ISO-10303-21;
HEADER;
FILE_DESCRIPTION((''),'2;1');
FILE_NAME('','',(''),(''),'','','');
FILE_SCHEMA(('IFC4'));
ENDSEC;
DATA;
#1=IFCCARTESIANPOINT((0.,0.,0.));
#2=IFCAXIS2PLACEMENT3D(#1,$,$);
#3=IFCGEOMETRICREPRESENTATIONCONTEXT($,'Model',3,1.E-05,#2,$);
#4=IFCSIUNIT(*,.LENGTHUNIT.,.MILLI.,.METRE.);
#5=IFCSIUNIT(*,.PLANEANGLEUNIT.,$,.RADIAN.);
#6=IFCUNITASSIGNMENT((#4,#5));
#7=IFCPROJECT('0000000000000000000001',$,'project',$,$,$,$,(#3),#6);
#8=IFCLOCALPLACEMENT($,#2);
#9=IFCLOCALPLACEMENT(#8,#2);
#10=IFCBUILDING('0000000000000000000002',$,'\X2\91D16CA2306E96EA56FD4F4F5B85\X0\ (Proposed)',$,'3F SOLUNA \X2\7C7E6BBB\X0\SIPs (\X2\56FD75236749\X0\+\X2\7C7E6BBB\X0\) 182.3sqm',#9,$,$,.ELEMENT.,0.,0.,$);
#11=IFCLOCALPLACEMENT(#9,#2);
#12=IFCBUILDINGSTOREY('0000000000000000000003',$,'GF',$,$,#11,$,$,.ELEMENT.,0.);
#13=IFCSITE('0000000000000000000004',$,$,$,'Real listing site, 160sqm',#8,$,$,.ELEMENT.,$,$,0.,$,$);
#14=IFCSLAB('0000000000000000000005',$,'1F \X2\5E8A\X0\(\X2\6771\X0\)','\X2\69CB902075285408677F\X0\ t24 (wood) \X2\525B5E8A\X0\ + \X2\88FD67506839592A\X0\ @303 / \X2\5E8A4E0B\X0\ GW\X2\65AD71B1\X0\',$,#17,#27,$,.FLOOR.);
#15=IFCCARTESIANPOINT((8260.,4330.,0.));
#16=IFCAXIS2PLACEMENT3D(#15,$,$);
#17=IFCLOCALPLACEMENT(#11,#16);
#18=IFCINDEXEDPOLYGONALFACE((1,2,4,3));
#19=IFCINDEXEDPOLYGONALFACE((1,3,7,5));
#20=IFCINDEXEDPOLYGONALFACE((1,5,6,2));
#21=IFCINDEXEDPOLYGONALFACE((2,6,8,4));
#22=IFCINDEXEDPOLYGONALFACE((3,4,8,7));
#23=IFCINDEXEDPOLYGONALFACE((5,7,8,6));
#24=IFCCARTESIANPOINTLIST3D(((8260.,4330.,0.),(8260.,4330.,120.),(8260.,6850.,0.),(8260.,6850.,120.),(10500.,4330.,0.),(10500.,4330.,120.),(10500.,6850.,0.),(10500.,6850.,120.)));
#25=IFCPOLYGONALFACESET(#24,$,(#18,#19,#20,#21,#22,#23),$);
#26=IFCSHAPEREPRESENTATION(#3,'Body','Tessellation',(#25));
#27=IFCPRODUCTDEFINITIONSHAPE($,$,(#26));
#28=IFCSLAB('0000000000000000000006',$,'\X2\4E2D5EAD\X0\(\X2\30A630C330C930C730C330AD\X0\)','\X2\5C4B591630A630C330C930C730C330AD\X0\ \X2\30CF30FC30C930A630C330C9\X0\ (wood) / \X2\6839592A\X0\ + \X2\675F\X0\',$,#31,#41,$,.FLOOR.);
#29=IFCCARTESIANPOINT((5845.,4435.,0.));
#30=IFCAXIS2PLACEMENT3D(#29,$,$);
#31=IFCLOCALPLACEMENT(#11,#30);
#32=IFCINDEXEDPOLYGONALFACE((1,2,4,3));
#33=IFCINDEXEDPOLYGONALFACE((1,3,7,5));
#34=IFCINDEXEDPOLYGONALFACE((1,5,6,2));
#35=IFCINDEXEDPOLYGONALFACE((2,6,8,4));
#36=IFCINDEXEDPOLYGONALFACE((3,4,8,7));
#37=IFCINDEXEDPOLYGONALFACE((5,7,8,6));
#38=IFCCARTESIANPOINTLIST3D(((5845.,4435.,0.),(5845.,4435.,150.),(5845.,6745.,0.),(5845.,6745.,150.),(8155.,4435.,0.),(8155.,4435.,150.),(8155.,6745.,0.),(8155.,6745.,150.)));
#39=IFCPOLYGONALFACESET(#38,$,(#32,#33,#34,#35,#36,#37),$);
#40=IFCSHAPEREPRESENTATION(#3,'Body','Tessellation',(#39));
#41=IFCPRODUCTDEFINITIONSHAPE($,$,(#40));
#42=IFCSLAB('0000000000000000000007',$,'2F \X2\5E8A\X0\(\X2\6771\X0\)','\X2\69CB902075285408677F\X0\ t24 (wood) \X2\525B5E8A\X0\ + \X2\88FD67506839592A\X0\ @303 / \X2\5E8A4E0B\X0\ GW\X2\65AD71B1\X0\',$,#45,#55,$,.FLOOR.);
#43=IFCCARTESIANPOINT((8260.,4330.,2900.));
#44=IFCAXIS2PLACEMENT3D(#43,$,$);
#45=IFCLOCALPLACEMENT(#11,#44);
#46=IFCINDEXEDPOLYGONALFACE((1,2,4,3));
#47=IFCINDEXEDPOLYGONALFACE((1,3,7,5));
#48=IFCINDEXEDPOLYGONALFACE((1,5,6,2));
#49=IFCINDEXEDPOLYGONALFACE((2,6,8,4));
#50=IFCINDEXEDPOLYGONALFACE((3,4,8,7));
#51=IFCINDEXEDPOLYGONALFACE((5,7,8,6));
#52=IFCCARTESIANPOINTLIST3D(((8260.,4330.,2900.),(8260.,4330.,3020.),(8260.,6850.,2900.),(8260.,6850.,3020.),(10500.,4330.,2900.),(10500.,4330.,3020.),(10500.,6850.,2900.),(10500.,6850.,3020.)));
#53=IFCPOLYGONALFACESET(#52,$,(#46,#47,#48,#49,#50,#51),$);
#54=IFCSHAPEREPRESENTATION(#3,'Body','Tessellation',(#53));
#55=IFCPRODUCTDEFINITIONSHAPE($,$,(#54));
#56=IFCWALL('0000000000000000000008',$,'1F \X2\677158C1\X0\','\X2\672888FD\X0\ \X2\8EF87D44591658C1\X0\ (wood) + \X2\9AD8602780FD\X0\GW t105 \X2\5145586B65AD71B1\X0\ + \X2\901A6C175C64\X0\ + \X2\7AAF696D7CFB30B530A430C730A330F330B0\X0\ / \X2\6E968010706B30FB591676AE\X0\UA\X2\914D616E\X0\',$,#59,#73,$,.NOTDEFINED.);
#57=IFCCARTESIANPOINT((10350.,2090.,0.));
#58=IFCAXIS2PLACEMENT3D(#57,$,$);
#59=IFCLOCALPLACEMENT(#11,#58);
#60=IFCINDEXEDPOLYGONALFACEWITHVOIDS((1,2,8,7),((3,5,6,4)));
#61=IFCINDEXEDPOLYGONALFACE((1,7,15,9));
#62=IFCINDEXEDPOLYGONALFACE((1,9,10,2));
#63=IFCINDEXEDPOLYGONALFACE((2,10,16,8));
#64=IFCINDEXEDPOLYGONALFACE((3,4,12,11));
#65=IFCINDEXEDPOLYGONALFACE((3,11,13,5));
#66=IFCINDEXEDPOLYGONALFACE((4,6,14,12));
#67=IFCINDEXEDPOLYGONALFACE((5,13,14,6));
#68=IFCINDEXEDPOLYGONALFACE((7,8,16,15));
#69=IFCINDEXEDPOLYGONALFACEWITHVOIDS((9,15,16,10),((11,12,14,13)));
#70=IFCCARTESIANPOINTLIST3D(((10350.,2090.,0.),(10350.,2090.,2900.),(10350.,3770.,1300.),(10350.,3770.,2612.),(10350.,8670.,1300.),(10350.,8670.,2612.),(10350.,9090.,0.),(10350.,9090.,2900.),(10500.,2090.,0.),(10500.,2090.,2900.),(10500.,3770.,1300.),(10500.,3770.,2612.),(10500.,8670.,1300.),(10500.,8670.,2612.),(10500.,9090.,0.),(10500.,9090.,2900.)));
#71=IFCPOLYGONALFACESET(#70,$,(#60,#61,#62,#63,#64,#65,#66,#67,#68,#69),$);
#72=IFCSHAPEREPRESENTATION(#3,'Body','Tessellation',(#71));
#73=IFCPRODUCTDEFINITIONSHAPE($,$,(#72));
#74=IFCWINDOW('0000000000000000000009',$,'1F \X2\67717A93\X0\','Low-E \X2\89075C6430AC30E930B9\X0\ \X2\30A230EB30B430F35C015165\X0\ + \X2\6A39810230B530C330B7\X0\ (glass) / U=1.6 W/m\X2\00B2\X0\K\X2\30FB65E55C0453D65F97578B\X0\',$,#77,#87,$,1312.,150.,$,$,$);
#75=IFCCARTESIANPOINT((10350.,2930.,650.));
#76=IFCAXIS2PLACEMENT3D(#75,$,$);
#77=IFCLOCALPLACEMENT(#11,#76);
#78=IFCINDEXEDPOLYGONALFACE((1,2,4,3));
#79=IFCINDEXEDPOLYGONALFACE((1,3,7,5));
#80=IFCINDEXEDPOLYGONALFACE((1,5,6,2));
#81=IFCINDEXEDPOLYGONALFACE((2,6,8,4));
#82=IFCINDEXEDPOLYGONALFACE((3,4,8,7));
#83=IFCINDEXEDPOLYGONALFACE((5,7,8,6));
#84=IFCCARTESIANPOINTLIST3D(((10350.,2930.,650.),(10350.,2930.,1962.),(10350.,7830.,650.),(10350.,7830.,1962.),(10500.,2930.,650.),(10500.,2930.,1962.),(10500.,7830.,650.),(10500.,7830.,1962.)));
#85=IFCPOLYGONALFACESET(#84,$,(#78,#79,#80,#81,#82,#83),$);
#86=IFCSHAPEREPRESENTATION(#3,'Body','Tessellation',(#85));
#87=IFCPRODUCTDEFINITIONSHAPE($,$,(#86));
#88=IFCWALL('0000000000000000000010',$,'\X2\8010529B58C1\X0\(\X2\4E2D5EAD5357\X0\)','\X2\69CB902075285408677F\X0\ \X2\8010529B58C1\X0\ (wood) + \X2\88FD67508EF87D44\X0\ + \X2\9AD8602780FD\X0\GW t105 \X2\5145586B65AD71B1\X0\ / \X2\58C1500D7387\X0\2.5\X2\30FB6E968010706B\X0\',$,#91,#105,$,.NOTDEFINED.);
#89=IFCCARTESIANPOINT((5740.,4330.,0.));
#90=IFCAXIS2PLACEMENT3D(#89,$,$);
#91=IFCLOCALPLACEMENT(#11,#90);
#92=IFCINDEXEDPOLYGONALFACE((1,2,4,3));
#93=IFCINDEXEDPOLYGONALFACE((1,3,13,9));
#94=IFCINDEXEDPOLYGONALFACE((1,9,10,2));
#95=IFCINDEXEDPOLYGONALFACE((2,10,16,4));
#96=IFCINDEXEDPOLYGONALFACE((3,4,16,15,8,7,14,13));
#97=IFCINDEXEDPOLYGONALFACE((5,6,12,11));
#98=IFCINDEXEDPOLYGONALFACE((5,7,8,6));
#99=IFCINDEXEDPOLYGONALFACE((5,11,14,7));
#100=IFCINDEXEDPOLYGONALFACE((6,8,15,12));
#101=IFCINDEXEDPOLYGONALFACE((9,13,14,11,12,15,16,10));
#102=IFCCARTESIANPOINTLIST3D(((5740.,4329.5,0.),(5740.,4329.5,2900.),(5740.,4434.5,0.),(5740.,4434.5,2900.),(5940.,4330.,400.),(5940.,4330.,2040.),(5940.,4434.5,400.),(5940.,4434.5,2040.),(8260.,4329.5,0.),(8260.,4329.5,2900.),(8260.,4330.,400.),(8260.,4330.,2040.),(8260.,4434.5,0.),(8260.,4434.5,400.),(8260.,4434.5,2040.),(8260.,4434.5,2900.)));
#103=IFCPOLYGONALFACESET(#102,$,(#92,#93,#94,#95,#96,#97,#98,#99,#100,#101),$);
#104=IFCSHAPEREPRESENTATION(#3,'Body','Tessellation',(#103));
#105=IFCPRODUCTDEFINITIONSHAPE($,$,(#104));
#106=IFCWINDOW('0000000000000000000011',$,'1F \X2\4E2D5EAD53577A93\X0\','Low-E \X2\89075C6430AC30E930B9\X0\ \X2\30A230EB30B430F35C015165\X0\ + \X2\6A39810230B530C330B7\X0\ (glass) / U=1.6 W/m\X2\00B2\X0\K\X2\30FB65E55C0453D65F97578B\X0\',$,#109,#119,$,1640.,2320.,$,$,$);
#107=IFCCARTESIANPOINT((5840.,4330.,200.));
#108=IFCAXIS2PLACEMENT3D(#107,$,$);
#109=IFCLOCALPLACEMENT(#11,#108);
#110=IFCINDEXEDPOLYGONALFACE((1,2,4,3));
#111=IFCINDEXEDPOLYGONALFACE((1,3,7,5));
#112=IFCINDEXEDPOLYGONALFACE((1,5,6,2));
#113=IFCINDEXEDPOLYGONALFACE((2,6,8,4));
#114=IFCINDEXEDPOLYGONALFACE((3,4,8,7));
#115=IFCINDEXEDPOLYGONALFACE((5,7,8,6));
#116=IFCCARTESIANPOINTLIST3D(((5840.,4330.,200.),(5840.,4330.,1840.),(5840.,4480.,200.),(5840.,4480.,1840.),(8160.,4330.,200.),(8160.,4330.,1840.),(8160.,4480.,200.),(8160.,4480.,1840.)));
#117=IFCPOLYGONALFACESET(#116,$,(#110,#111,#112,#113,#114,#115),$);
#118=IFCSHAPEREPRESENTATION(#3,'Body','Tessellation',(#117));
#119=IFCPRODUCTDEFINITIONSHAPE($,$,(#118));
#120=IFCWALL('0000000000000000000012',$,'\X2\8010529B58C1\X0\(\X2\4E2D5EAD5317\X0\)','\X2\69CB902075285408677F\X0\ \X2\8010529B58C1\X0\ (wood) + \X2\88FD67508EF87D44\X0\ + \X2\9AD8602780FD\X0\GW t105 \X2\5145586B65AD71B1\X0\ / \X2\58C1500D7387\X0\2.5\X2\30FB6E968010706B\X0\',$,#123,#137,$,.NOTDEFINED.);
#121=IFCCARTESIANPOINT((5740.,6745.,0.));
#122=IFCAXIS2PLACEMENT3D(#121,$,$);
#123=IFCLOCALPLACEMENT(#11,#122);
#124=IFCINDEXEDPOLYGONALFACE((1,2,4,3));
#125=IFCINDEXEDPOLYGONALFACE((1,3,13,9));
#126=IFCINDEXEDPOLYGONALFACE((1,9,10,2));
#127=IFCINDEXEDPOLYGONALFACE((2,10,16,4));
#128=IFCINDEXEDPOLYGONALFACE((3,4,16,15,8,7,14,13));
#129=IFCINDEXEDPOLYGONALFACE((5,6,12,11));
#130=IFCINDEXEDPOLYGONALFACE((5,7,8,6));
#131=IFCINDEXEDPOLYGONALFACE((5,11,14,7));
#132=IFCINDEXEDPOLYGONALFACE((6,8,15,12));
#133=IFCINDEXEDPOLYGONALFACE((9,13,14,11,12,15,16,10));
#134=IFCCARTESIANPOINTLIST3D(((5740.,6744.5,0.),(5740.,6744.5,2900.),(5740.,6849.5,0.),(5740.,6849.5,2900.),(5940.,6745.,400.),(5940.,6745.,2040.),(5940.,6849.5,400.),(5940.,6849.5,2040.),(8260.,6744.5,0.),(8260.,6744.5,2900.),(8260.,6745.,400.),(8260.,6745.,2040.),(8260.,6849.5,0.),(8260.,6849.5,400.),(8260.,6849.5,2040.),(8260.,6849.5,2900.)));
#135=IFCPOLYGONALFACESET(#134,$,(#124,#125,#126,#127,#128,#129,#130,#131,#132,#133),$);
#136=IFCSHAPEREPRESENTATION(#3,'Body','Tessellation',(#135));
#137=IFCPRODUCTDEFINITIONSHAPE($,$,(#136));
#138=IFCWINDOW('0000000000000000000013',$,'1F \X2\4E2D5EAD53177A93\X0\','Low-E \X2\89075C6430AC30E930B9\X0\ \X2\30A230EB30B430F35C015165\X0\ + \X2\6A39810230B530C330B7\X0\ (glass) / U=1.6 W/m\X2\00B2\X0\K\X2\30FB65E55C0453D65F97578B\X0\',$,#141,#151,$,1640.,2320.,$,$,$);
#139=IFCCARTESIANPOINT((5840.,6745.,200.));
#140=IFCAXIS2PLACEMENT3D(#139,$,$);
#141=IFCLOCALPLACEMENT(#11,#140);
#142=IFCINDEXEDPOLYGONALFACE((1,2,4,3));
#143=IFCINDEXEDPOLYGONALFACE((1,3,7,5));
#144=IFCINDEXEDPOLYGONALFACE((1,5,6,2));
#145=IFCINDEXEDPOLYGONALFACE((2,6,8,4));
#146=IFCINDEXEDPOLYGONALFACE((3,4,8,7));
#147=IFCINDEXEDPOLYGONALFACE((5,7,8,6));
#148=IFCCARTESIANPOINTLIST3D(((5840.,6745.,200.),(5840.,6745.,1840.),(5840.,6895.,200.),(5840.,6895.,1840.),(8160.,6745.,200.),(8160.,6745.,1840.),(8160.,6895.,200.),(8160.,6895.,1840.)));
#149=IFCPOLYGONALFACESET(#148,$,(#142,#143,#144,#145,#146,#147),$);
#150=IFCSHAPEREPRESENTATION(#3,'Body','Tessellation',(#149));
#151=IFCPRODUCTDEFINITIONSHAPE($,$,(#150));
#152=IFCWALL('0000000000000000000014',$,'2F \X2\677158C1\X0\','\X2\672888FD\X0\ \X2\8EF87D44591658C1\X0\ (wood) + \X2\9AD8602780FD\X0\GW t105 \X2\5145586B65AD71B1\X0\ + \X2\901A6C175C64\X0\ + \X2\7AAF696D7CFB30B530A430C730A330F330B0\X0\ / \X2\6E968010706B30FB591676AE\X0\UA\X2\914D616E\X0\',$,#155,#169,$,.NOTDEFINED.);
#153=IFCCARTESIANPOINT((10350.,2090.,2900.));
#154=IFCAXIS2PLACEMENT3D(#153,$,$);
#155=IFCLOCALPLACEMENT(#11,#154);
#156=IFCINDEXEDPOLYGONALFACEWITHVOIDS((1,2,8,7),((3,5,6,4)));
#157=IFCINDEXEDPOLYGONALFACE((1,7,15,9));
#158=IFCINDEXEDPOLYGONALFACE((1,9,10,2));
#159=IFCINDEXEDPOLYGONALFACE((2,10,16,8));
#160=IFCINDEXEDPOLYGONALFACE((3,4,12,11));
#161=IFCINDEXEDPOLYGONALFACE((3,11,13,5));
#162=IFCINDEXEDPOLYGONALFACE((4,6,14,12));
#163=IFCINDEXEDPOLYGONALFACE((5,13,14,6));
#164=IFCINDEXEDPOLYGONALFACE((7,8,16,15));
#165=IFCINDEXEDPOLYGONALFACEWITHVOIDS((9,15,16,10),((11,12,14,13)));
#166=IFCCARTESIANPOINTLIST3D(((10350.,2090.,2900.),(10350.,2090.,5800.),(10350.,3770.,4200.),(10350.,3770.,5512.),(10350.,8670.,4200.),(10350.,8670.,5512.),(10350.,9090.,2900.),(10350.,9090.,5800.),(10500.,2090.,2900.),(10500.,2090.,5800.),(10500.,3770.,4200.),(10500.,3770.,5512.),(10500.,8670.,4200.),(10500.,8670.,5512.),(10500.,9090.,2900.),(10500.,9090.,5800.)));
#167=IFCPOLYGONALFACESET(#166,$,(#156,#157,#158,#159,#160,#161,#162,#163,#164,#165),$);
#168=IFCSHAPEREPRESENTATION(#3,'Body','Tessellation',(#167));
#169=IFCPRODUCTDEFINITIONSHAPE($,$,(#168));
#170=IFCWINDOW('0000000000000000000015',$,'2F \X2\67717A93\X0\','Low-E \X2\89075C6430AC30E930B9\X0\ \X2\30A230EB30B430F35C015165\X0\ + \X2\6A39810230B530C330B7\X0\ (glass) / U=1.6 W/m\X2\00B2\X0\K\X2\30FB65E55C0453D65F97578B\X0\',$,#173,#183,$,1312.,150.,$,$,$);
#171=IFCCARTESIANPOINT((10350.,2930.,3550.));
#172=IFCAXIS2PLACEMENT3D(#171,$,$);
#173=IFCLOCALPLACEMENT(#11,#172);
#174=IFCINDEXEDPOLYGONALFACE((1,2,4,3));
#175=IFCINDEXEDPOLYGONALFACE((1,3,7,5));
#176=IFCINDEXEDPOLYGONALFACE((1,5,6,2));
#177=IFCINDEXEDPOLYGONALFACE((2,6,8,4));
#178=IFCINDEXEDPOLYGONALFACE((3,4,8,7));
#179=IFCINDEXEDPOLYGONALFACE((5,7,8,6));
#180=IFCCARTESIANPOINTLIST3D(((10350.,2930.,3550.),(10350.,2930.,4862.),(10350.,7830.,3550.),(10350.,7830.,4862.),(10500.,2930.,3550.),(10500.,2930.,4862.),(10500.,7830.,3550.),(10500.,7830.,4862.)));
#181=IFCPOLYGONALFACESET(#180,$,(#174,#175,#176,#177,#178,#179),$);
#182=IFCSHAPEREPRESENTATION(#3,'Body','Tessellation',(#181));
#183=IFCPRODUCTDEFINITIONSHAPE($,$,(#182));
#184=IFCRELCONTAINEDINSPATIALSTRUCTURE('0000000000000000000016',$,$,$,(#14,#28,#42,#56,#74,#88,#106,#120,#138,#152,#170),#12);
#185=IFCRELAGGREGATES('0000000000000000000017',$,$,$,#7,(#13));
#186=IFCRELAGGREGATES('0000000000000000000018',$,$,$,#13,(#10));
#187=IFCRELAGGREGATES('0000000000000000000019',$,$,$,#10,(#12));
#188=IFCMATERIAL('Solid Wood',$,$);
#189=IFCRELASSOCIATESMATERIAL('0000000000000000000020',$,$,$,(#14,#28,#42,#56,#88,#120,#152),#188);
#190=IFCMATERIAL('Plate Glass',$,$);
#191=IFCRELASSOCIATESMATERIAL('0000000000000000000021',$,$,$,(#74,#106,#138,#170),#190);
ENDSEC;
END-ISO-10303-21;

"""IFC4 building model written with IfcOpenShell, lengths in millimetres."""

from ifc_helpers import new_model, si_unit, frame, frame_2d, origin, place, context, project, spatial, rectangle, extrude, material, element, fill, save


model = new_model("IFC4")

# Units and contexts
model_context = context("Model", 3, precision=1e-05, world=origin())
ifc_project = project(units=[si_unit("LENGTHUNIT", "METRE", prefix="MILLI"), si_unit("PLANEANGLEUNIT", "RADIAN")], contexts=[model_context])

# Site, building, storey
site_placement = place(None, origin())
site = spatial("IfcSite", under=ifc_project, at=site_placement, ObjectType="Real listing site, 160sqm", CompositionType="ELEMENT", RefElevation=0.0)
building_placement = place(site_placement, origin())
building = spatial("IfcBuilding", under=site, at=building_placement, Name="金沢の雪国住宅 (Proposed)", ObjectType="3F SOLUNA 籾殻SIPs (国産杉+籾殻) 182.3sqm", CompositionType="ELEMENT", ElevationOfRefHeight=0.0, ElevationOfTerrain=0.0)
storey_placement = place(building_placement, origin())
storey = spatial("IfcBuildingStorey", under=building, at=storey_placement, Name="GF", CompositionType="ELEMENT", Elevation=0.0)

# Slabs
ifc_material_1 = material(Name="Solid Wood")
slab_1_placement = place(storey_placement, frame((8260.0, 4330.0, 0.0)))
element("IfcSlab", 1, at=slab_1_placement, inside=storey, material=ifc_material_1, Name="1F 床(東)", Description="構造用合板 t24 (wood) 剛床 + 製材根太 @303 / 床下 GW断熱", PredefinedType="FLOOR", context=model_context, shape_type="SweptSolid", body=[
    extrude(rectangle(XDim=2240.0, YDim=2520.0, at=frame_2d((1120.0, 1260.0))), frame((8260.0, 4330.0, 0.0)), (0.0, 0.0, 1.0), 120.0),
])
slab_2_placement = place(storey_placement, frame((5845.0, 4435.0, 0.0)))
element("IfcSlab", 2, at=slab_2_placement, inside=storey, material=ifc_material_1, Name="中庭(ウッドデッキ)", Description="屋外ウッドデッキ ハードウッド (wood) / 根太 + 束", PredefinedType="FLOOR", context=model_context, shape_type="SweptSolid", body=[
    extrude(rectangle(XDim=2310.0, YDim=2310.0, at=frame_2d((1155.0, 1155.0))), frame((5845.0, 4435.0, 0.0)), (0.0, 0.0, 1.0), 150.0),
])
slab_3_placement = place(storey_placement, frame((8260.0, 4330.0, 2900.0)))
element("IfcSlab", 3, at=slab_3_placement, inside=storey, material=ifc_material_1, Name="2F 床(東)", Description="構造用合板 t24 (wood) 剛床 + 製材根太 @303 / 床下 GW断熱", PredefinedType="FLOOR", context=model_context, shape_type="SweptSolid", body=[
    extrude(rectangle(XDim=2240.0, YDim=2520.0, at=frame_2d((1120.0, 1260.0))), frame((8260.0, 4330.0, 2900.0)), (0.0, 0.0, 1.0), 120.0),
])

# Walls, openings, windows
wall_1_placement = place(storey_placement, frame((10350.0, 2090.0, 0.0)))
wall_1 = element("IfcWall", 4, at=wall_1_placement, inside=storey, material=ifc_material_1, Name="1F 東壁", Description="木製 軸組外壁 (wood) + 高性能GW t105 充填断熱 + 通気層 + 窯業系サイディング / 準耐火・外皮UA配慮", PredefinedType="NOTDEFINED", context=model_context, shape_type="SweptSolid", body=[
    extrude(rectangle(XDim=150.0, YDim=7000.0, at=frame_2d((75.0, 3500.0))), frame((10350.0, 2090.0, 0.0)), (0.0, 0.0, 1.0), 2900.0),
])
opening_1_placement = place(storey_placement, frame((10350.0, 2930.0, 650.0)))
opening_1 = element("IfcOpeningElement", 5, at=opening_1_placement, cuts=wall_1, PredefinedType="NOTDEFINED", context=model_context, shape_type="SweptSolid", body=[
    extrude(rectangle(XDim=150.0, YDim=4900.0, at=frame_2d((75.0, 2450.0))), frame((10350.0, 2930.0, 650.0)), (0.0, 0.0, 1.0), 1312.0),
])
ifc_material_2 = material(Name="Plate Glass")
window_1_placement = place(storey_placement, frame((10350.0, 2930.0, 650.0)))
window_1 = element("IfcWindow", 6, at=window_1_placement, inside=storey, material=ifc_material_2, Name="1F 東窓", Description="Low-E 複層ガラス アルゴン封入 + 樹脂サッシ (glass) / U=1.6 W/m²K・日射取得型", OverallHeight=1312.0, OverallWidth=150.0, context=model_context, shape_type="SweptSolid", body=[
    extrude(rectangle(XDim=150.0, YDim=4900.0, at=frame_2d((75.0, 2450.0))), frame((10350.0, 2930.0, 650.0)), (0.0, 0.0, 1.0), 1312.0),
])
fill(opening_1, window_1)
wall_2_placement = place(storey_placement, frame((5740.0, 4330.0, 0.0)))
wall_2 = element("IfcWall", 7, at=wall_2_placement, inside=storey, material=ifc_material_1, Name="耐力壁(中庭南)", Description="構造用合板 耐力壁 (wood) + 製材軸組 + 高性能GW t105 充填断熱 / 壁倍率2.5・準耐火", PredefinedType="NOTDEFINED", context=model_context, shape_type="SweptSolid", body=[
    extrude(rectangle(XDim=2520.0, YDim=105.0, at=frame_2d((1260.0, 52.0))), frame((5740.0, 4330.0, 0.0)), (0.0, 0.0, 1.0), 2900.0),
])
opening_2_placement = place(storey_placement, frame((5840.0, 4330.0, 200.0)))
opening_2 = element("IfcOpeningElement", 8, at=opening_2_placement, cuts=wall_2, PredefinedType="NOTDEFINED", context=model_context, shape_type="SweptSolid", body=[
    extrude(rectangle(XDim=2320.0, YDim=150.0, at=frame_2d((1160.0, 75.0))), frame((5840.0, 4330.0, 200.0)), (0.0, 0.0, 1.0), 1640.0),
])
window_2_placement = place(storey_placement, frame((5840.0, 4330.0, 200.0)))
window_2 = element("IfcWindow", 9, at=window_2_placement, inside=storey, material=ifc_material_2, Name="1F 中庭南窓", Description="Low-E 複層ガラス アルゴン封入 + 樹脂サッシ (glass) / U=1.6 W/m²K・日射取得型", OverallHeight=1640.0, OverallWidth=2320.0, context=model_context, shape_type="SweptSolid", body=[
    extrude(rectangle(XDim=2320.0, YDim=150.0, at=frame_2d((1160.0, 75.0))), frame((5840.0, 4330.0, 200.0)), (0.0, 0.0, 1.0), 1640.0),
])
fill(opening_2, window_2)
wall_3_placement = place(storey_placement, frame((5740.0, 6745.0, 0.0)))
wall_3 = element("IfcWall", 10, at=wall_3_placement, inside=storey, material=ifc_material_1, Name="耐力壁(中庭北)", Description="構造用合板 耐力壁 (wood) + 製材軸組 + 高性能GW t105 充填断熱 / 壁倍率2.5・準耐火", PredefinedType="NOTDEFINED", context=model_context, shape_type="SweptSolid", body=[
    extrude(rectangle(XDim=2520.0, YDim=105.0, at=frame_2d((1260.0, 52.0))), frame((5740.0, 6745.0, 0.0)), (0.0, 0.0, 1.0), 2900.0),
])
opening_3_placement = place(storey_placement, frame((5840.0, 6745.0, 200.0)))
opening_3 = element("IfcOpeningElement", 11, at=opening_3_placement, cuts=wall_3, PredefinedType="NOTDEFINED", context=model_context, shape_type="SweptSolid", body=[
    extrude(rectangle(XDim=2320.0, YDim=150.0, at=frame_2d((1160.0, 75.0))), frame((5840.0, 6745.0, 200.0)), (0.0, 0.0, 1.0), 1640.0),
])
window_3_placement = place(storey_placement, frame((5840.0, 6745.0, 200.0)))
window_3 = element("IfcWindow", 12, at=window_3_placement, inside=storey, material=ifc_material_2, Name="1F 中庭北窓", Description="Low-E 複層ガラス アルゴン封入 + 樹脂サッシ (glass) / U=1.6 W/m²K・日射取得型", OverallHeight=1640.0, OverallWidth=2320.0, context=model_context, shape_type="SweptSolid", body=[
    extrude(rectangle(XDim=2320.0, YDim=150.0, at=frame_2d((1160.0, 75.0))), frame((5840.0, 6745.0, 200.0)), (0.0, 0.0, 1.0), 1640.0),
])
fill(opening_3, window_3)

# Wall, opening, window
wall_4_placement = place(storey_placement, frame((10350.0, 2090.0, 2900.0)))
wall_4 = element("IfcWall", 13, at=wall_4_placement, inside=storey, material=ifc_material_1, Name="2F 東壁", Description="木製 軸組外壁 (wood) + 高性能GW t105 充填断熱 + 通気層 + 窯業系サイディング / 準耐火・外皮UA配慮", PredefinedType="NOTDEFINED", context=model_context, shape_type="SweptSolid", body=[
    extrude(rectangle(XDim=150.0, YDim=7000.0, at=frame_2d((75.0, 3500.0))), frame((10350.0, 2090.0, 2900.0)), (0.0, 0.0, 1.0), 2900.0),
])
opening_4_placement = place(storey_placement, frame((10350.0, 2930.0, 3550.0)))
opening_4 = element("IfcOpeningElement", 14, at=opening_4_placement, cuts=wall_4, PredefinedType="NOTDEFINED", context=model_context, shape_type="SweptSolid", body=[
    extrude(rectangle(XDim=150.0, YDim=4900.0, at=frame_2d((75.0, 2450.0))), frame((10350.0, 2930.0, 3550.0)), (0.0, 0.0, 1.0), 1312.0),
])
window_4_placement = place(storey_placement, frame((10350.0, 2930.0, 3550.0)))
window_4 = element("IfcWindow", 15, at=window_4_placement, inside=storey, material=ifc_material_2, Name="2F 東窓", Description="Low-E 複層ガラス アルゴン封入 + 樹脂サッシ (glass) / U=1.6 W/m²K・日射取得型", OverallHeight=1312.0, OverallWidth=150.0, context=model_context, shape_type="SweptSolid", body=[
    extrude(rectangle(XDim=150.0, YDim=4900.0, at=frame_2d((75.0, 2450.0))), frame((10350.0, 2930.0, 3550.0)), (0.0, 0.0, 1.0), 1312.0),
])
fill(opening_4, window_4)

save(model, "model.ifc")
